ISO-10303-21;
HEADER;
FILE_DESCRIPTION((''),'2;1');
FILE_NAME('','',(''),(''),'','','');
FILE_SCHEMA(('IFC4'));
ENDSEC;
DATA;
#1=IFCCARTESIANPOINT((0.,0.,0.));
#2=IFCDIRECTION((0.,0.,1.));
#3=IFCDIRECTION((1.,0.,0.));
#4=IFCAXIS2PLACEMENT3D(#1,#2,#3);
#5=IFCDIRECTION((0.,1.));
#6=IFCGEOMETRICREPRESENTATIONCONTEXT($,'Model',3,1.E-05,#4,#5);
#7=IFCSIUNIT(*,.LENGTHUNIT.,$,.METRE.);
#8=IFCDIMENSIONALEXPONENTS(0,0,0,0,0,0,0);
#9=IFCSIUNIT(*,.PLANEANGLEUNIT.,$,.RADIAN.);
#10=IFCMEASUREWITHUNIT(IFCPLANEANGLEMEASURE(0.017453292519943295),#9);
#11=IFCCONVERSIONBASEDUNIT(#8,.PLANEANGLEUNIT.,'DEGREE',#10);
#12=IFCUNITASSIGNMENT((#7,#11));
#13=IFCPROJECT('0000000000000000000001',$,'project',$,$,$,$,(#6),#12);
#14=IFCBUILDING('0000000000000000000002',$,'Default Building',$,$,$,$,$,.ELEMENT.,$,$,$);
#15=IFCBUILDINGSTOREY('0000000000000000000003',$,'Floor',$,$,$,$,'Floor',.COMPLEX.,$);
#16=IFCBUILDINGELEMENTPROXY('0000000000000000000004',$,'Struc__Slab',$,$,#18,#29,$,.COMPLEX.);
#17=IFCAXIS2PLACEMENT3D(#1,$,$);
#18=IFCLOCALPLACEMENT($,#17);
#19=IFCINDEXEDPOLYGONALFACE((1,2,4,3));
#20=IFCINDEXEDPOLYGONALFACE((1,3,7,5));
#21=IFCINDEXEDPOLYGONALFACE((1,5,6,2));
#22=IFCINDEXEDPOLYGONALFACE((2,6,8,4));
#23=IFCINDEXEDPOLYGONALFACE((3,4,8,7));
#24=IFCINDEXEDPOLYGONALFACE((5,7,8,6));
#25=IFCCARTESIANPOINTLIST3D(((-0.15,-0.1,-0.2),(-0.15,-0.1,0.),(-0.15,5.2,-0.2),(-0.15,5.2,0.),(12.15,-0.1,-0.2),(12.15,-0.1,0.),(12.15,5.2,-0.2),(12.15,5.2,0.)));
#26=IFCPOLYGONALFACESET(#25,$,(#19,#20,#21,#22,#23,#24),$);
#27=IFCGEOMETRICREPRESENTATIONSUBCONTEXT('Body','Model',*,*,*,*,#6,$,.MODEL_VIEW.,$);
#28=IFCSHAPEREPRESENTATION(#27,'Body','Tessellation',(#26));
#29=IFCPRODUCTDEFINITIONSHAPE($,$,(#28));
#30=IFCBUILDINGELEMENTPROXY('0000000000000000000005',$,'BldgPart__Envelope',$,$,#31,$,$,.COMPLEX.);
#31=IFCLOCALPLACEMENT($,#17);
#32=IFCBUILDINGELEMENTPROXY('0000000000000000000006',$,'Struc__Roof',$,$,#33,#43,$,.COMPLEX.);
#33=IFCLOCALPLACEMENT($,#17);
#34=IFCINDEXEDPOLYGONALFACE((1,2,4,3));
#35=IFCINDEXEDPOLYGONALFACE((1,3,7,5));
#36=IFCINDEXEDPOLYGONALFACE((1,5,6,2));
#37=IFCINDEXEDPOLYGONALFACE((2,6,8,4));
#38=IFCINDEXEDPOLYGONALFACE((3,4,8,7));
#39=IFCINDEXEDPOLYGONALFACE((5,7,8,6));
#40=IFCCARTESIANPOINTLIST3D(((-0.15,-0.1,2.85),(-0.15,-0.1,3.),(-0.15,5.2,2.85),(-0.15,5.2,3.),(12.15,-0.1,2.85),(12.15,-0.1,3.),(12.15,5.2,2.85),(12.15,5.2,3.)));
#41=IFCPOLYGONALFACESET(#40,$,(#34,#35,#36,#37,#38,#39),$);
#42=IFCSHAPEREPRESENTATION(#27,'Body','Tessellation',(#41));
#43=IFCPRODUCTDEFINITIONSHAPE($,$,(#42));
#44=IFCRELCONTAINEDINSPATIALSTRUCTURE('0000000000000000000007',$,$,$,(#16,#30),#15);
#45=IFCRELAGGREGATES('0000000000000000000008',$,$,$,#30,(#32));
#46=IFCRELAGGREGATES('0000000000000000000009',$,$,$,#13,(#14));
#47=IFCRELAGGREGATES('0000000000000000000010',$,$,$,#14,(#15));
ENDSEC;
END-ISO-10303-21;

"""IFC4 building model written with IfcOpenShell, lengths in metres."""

from ifc_helpers import new_model, entity, si_unit, converted_unit, direction, frame, origin_with_axes, place, context, subcontext, project, spatial, polyline, outline, extrude, element, aggregate, save


model = new_model("IFC4")

# Units and contexts
model_context = context("Model", 3, precision=1e-05, world=origin_with_axes(), true_north=direction((0.0, 1.0)))
body_context = subcontext(model_context, "Body", "Model", "MODEL_VIEW")
ifc_project = project(units=[si_unit("LENGTHUNIT", "METRE"), converted_unit("PLANEANGLEUNIT", "DEGREE", entity("IfcPlaneAngleMeasure", 0.017453292519943295), si_unit("PLANEANGLEUNIT", "RADIAN"), dimensions=[0, 0, 0, 0, 0, 0, 0])], contexts=[model_context])

# Building, storey
building = spatial("IfcBuilding", under=ifc_project, Name="Default Building", CompositionType="ELEMENT")
storey = spatial("IfcBuildingStorey", under=building, Name="Floor", LongName="Floor", CompositionType="COMPLEX")

# Building element proxy
placement = place(None, origin_with_axes())
element("IfcBuildingElementProxy", 1, at=placement, inside=storey, Name="Struc__Slab", PredefinedType="COMPLEX", context=body_context, shape_type="SweptSolid", body=[
    extrude(outline(polyline([(-6.15, 2.65), (6.15, 2.65), (6.15, -2.65), (-6.15, -2.65), (-6.15, 2.65)])), frame((6.0, 2.55, 0.0), z_axis=(0.0, 0.0, 1.0), x_axis=(1.0, 0.0, 0.0)), (0.0, 0.0, -1.0), 0.2),
])

# Building element proxies
proxy_1 = element("IfcBuildingElementProxy", 2, inside=storey, Name="BldgPart__Envelope", PredefinedType="COMPLEX")
proxy_2 = element("IfcBuildingElementProxy", 3, at=placement, Name="Struc__Roof", PredefinedType="COMPLEX", context=body_context, shape_type="SweptSolid", body=[
    extrude(outline(polyline([(-6.15, 2.65), (6.15, 2.65), (6.15, -2.65), (-6.15, -2.65), (-6.15, 2.65)])), frame((6.0, 2.55, 3.0), z_axis=(0.0, 0.0, 1.0), x_axis=(1.0, 0.0, 0.0)), (0.0, 0.0, -1.0), 0.15),
])
aggregate(proxy_1, [proxy_2])

save(model, "model.ifc")
